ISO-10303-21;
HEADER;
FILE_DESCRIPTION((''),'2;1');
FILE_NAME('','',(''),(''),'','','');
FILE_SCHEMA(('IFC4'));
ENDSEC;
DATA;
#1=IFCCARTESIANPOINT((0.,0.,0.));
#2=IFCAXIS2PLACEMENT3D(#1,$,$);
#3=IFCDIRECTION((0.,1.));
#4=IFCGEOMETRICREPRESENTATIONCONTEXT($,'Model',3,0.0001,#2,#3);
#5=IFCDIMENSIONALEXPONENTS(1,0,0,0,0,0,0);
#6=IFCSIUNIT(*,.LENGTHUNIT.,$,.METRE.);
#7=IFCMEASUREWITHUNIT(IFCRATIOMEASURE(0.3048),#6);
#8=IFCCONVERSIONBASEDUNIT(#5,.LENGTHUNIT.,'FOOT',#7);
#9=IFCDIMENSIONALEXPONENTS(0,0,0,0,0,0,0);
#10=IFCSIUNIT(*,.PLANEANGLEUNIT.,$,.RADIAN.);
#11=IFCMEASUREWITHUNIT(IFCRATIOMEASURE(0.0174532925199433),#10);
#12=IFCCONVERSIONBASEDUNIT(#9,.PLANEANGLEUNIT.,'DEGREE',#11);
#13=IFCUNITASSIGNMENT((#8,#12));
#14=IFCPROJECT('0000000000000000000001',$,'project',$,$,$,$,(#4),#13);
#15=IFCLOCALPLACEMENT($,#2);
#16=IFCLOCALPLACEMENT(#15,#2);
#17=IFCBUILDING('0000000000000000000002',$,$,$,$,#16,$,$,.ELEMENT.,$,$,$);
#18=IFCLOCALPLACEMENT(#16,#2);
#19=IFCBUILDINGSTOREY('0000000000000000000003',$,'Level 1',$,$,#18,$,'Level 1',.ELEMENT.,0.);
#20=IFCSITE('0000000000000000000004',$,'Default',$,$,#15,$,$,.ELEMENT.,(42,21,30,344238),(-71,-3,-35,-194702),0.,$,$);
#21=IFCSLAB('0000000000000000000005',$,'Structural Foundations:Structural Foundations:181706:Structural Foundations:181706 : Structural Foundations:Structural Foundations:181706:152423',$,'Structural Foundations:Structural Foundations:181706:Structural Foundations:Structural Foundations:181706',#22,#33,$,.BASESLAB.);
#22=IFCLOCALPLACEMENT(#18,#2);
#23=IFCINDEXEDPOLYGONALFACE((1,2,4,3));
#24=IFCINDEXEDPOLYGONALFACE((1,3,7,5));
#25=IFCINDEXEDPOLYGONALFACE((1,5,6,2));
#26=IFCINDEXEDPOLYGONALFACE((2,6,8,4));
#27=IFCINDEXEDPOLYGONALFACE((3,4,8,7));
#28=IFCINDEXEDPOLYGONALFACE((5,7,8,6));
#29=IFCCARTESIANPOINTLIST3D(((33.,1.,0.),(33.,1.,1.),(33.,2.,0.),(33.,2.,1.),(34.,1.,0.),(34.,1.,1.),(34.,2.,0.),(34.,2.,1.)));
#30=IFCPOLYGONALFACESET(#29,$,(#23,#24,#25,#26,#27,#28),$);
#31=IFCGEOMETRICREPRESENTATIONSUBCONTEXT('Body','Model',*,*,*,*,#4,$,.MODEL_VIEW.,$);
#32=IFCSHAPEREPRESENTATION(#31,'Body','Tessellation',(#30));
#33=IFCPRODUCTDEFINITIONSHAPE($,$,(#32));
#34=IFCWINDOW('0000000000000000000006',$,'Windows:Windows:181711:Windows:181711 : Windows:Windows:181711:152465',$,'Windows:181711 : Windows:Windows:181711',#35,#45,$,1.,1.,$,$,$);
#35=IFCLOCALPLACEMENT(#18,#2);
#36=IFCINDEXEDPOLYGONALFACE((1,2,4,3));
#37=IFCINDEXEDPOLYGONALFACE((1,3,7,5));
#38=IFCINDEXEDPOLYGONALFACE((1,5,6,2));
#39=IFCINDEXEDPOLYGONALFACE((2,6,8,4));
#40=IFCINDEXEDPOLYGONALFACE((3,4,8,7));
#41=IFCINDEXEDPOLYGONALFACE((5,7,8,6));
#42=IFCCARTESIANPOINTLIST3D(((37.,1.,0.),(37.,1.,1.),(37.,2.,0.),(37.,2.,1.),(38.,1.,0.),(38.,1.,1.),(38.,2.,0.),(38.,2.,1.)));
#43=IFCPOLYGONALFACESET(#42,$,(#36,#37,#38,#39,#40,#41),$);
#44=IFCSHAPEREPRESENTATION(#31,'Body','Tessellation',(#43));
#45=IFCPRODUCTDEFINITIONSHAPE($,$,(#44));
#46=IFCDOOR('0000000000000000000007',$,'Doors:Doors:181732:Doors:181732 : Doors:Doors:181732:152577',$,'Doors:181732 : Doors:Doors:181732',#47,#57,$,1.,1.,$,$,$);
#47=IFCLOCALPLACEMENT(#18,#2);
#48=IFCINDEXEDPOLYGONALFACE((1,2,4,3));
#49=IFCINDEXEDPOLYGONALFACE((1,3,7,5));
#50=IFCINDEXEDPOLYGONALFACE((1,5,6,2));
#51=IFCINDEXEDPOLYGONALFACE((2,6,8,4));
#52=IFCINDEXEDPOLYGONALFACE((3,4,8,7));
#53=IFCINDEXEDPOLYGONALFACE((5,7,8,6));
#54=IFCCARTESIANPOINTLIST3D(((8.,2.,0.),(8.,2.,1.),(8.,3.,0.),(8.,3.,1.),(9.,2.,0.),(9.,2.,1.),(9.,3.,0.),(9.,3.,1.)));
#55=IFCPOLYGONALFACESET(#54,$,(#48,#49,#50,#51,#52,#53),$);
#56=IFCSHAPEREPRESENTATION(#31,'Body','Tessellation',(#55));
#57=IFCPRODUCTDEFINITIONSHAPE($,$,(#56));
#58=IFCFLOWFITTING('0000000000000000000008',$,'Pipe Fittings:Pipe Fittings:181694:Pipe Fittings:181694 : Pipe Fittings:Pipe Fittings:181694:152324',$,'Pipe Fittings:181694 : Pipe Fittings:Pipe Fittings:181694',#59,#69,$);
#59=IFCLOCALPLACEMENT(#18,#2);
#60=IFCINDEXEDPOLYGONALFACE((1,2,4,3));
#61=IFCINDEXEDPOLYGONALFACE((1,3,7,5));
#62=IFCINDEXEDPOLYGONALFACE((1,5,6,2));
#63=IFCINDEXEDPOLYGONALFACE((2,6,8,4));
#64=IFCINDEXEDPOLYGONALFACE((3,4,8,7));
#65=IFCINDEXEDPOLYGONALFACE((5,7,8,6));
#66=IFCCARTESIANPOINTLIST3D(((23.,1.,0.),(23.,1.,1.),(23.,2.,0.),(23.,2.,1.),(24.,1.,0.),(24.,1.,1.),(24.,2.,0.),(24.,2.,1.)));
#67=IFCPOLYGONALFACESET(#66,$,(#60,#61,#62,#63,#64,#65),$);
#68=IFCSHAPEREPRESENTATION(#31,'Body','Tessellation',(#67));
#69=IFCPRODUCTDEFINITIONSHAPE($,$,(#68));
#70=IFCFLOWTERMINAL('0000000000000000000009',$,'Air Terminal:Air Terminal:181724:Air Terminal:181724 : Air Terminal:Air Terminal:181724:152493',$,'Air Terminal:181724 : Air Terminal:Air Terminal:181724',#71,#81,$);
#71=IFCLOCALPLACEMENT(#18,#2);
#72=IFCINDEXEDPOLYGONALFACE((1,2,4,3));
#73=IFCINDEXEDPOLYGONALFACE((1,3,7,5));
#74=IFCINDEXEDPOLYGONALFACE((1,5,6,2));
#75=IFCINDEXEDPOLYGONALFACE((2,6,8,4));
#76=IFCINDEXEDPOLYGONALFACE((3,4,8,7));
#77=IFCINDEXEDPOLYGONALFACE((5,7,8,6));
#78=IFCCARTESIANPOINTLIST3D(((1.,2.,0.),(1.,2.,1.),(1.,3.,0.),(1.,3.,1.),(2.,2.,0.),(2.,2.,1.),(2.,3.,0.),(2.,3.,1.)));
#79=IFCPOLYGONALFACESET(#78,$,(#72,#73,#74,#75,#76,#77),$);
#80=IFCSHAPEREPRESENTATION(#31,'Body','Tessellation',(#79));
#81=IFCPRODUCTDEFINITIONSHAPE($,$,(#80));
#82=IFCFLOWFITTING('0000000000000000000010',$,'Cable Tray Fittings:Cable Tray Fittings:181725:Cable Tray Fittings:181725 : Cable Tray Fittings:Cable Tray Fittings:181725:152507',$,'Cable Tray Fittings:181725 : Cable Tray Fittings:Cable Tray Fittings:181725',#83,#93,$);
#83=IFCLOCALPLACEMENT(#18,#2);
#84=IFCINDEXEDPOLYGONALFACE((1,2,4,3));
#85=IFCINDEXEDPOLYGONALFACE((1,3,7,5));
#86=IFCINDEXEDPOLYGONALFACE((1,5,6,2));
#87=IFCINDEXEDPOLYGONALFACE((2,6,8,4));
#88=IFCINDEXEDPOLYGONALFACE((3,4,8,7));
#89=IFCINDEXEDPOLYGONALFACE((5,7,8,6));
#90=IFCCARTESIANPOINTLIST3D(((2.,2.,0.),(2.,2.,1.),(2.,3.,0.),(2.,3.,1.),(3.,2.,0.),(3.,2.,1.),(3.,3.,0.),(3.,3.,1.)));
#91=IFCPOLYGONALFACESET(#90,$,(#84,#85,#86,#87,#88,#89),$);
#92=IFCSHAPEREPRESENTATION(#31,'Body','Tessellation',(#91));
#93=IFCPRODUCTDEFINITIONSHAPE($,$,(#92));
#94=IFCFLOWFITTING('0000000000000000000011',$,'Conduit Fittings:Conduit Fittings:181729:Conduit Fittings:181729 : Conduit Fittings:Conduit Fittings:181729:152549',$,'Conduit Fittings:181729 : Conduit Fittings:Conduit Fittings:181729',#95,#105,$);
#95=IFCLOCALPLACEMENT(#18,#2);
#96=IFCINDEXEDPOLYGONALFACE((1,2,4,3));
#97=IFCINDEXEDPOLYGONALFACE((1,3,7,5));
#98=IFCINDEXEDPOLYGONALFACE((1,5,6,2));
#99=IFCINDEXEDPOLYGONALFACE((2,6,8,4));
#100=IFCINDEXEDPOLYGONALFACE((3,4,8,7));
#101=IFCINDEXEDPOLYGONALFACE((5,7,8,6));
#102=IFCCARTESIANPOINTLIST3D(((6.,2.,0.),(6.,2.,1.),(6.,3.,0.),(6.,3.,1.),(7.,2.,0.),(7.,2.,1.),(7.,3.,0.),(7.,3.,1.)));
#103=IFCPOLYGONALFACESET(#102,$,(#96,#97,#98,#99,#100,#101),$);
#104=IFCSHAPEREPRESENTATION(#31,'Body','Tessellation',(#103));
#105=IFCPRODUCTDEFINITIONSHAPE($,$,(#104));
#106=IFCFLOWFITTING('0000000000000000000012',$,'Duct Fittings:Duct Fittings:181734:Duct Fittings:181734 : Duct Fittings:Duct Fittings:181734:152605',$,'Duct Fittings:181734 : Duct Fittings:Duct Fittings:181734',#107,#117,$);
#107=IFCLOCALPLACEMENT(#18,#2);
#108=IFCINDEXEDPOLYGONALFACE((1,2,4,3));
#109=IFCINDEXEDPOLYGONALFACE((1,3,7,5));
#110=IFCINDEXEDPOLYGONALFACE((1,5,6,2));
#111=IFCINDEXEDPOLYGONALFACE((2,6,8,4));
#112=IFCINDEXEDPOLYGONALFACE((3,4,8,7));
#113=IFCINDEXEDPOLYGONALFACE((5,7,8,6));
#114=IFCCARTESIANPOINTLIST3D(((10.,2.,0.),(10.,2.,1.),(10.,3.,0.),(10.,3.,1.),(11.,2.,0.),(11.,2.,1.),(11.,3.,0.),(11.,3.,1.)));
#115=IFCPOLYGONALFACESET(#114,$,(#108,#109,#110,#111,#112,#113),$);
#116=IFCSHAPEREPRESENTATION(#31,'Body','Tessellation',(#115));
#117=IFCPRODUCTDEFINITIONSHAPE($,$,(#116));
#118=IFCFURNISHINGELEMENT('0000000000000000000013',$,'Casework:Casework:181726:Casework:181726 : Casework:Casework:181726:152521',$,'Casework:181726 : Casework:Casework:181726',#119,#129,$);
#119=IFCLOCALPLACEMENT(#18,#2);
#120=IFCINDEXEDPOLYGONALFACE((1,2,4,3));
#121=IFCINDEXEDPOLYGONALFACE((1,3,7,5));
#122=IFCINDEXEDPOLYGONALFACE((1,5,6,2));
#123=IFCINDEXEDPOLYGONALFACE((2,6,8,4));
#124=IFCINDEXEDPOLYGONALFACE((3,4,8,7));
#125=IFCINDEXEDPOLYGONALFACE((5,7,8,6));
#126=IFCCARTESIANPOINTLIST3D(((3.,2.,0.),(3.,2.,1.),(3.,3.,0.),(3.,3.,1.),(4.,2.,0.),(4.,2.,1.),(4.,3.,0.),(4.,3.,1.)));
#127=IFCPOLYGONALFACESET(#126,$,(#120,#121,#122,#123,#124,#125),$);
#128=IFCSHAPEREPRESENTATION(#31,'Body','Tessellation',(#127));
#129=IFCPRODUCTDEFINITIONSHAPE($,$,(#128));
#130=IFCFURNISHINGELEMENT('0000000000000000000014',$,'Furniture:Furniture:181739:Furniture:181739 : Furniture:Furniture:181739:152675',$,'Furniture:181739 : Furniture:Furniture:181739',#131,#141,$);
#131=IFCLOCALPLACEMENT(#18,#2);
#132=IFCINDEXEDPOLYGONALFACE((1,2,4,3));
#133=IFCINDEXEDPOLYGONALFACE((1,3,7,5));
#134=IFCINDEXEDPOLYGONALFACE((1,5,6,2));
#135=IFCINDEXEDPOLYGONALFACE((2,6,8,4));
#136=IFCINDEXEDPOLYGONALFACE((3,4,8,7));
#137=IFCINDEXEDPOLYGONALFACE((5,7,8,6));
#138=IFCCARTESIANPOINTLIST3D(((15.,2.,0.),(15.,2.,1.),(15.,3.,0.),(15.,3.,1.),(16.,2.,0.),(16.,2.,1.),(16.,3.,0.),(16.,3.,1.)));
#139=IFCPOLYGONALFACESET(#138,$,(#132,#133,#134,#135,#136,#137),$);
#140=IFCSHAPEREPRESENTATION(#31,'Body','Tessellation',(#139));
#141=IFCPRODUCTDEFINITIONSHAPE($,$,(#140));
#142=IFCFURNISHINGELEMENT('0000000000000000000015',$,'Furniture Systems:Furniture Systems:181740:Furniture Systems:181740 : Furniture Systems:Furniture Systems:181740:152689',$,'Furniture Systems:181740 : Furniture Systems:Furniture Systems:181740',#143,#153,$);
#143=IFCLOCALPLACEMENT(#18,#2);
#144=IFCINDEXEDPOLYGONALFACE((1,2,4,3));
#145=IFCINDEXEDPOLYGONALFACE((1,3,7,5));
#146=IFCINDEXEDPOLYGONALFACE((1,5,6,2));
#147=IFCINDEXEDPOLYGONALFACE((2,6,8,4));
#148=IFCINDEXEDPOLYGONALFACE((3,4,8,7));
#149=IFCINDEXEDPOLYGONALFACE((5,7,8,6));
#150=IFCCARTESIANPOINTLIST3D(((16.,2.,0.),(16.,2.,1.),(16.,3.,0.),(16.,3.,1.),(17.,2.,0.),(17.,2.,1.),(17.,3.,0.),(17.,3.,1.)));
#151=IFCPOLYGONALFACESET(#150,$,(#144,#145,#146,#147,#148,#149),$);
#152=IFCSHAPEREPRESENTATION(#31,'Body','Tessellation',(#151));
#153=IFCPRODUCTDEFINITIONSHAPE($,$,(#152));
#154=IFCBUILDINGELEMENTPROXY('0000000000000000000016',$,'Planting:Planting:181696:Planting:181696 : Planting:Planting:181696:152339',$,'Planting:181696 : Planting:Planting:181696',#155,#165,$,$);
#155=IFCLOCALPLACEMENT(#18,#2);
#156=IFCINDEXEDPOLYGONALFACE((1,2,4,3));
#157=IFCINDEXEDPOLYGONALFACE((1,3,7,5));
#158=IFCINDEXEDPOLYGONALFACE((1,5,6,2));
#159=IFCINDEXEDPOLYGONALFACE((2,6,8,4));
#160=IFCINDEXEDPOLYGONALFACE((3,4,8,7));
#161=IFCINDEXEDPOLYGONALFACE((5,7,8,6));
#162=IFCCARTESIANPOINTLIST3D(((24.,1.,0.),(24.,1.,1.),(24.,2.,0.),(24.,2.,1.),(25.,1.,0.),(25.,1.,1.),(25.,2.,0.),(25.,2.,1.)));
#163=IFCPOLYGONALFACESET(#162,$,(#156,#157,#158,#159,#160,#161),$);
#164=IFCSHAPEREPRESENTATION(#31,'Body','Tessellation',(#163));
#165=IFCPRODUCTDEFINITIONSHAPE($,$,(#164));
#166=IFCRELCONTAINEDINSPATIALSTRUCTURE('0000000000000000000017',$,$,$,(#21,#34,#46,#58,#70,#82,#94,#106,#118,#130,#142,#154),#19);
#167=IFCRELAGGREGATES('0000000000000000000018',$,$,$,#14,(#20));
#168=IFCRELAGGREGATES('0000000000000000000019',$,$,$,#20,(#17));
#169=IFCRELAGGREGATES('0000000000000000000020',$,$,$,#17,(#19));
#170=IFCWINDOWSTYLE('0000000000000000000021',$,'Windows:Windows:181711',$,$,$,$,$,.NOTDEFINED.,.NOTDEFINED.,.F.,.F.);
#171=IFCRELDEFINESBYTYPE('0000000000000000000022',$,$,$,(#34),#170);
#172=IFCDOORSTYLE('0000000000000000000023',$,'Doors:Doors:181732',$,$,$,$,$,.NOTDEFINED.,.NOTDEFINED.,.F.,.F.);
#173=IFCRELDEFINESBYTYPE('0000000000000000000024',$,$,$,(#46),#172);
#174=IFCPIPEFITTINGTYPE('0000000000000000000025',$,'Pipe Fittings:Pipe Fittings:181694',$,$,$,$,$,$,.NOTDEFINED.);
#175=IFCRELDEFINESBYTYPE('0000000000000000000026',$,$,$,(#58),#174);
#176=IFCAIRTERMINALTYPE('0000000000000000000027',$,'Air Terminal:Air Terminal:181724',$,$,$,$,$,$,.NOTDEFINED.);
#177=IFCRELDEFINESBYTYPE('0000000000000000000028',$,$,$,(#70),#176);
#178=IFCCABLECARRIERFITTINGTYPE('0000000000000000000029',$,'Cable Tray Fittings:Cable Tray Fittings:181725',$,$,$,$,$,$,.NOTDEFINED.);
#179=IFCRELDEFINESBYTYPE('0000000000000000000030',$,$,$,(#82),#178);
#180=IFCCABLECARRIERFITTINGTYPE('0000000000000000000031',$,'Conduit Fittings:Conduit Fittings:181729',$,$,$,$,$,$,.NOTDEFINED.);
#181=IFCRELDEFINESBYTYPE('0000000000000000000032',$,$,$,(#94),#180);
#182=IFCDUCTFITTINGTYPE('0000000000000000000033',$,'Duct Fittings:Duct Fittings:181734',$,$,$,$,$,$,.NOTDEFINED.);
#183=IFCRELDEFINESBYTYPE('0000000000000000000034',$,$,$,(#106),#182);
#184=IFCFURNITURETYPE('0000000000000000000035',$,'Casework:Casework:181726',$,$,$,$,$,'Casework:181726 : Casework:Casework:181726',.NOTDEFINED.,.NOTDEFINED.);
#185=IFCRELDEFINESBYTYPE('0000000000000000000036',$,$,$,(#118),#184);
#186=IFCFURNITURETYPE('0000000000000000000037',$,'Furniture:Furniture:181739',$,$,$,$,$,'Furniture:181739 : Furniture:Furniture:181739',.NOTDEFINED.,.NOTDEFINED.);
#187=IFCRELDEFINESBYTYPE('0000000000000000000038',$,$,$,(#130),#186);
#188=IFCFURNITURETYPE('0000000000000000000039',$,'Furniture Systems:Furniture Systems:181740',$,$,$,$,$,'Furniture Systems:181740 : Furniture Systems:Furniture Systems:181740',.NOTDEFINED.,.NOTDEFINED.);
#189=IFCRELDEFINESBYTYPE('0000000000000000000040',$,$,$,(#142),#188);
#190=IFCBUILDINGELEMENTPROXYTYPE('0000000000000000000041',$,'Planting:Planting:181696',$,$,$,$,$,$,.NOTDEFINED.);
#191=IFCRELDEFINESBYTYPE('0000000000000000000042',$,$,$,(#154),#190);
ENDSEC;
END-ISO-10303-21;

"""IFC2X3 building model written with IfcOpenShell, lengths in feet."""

from ifc_helpers import new_model, entity, si_unit, converted_unit, direction, frame, frame_2d, origin, place, context, subcontext, project, spatial, rectangle, extrude, source, transform, mapped, type_object, type_shapes, element, save


model = new_model("IFC2X3")

# Units and contexts
model_context = context("Model", 3, precision=0.0001, world=origin(), true_north=direction((0.0, 1.0)))
body_context = subcontext(model_context, "Body", "Model", "MODEL_VIEW")
ifc_project = project(units=[converted_unit("LENGTHUNIT", "FOOT", entity("IfcRatioMeasure", 0.3048), si_unit("LENGTHUNIT", "METRE"), dimensions=[1, 0, 0, 0, 0, 0, 0]), converted_unit("PLANEANGLEUNIT", "DEGREE", entity("IfcRatioMeasure", 0.0174532925199433), si_unit("PLANEANGLEUNIT", "RADIAN"), dimensions=[0, 0, 0, 0, 0, 0, 0])], contexts=[model_context])

# Site, building, storey
site_placement = place(None, origin())
site = spatial("IfcSite", under=ifc_project, at=site_placement, Name="Default", CompositionType="ELEMENT", RefLatitude=(42, 21, 30, 344238), RefLongitude=(-71, -3, -35, -194702), RefElevation=0.0)
building_placement = place(site_placement, origin())
building = spatial("IfcBuilding", under=site, at=building_placement, CompositionType="ELEMENT")
storey_placement = place(building_placement, origin())
storey = spatial("IfcBuildingStorey", under=building, at=storey_placement, Name="Level 1", LongName="Level 1", CompositionType="ELEMENT", Elevation=0.0)

# Slab
slab_placement = place(storey_placement, origin())
element("IfcSlab", 1, at=slab_placement, inside=storey, Name="Structural Foundations:Structural Foundations:181706:Structural Foundations:181706 : Structural Foundations:Structural Foundations:181706:152423", ObjectType="Structural Foundations:Structural Foundations:181706:Structural Foundations:Structural Foundations:181706", PredefinedType="BASESLAB", context=body_context, shape_type="SweptSolid", body=[
    extrude(rectangle(XDim=1.0, YDim=1.0, at=frame_2d((0.0, 0.0), x_axis=(1.0, 0.0))), frame((33.5, 1.5, 0.0), z_axis=(0.0, 0.0, 1.0), x_axis=(-1.0, 0.0, 0.0)), (0.0, 0.0, 1.0), 1.0),
])

# Window
window_style = type_object("IfcWindowStyle", Name="Windows:Windows:181711", ConstructionType="NOTDEFINED", OperationType="NOTDEFINED", ParameterTakesPrecedence=False, Sizeable=False)
shared_shape_1 = source(origin(), body_context, "Body", "SweptSolid", [
    extrude(rectangle(XDim=1.0, YDim=1.0, at=frame_2d((0.0, 0.0), x_axis=(1.0, 0.0))), frame((37.5, 1.5, 0.0), z_axis=(0.0, 0.0, 1.0), x_axis=(-1.0, 0.0, 0.0)), (0.0, 0.0, 1.0), 1.0),
])
type_shapes(window_style, [shared_shape_1])
window_placement = place(storey_placement, origin())
element("IfcWindow", 2, at=window_placement, inside=storey, type_object=window_style, Name="Windows:Windows:181711:Windows:181711 : Windows:Windows:181711:152465", ObjectType="Windows:181711 : Windows:Windows:181711", OverallHeight=1.0, OverallWidth=1.0, context=body_context, shape_type="MappedRepresentation", body=[
    mapped(shared_shape_1, transform((0.0, 0.0, 0.0), scale=1.0)),
])

# Door
door_style = type_object("IfcDoorStyle", Name="Doors:Doors:181732", ConstructionType="NOTDEFINED", OperationType="NOTDEFINED", ParameterTakesPrecedence=False, Sizeable=False)
shared_shape_2 = source(origin(), body_context, "Body", "SweptSolid", [
    extrude(rectangle(XDim=1.0, YDim=1.0, at=frame_2d((0.0, 0.0), x_axis=(1.0, 0.0))), frame((8.5, 2.5, 0.0), z_axis=(0.0, 0.0, 1.0), x_axis=(-1.0, 0.0, 0.0)), (0.0, 0.0, 1.0), 1.0),
])
type_shapes(door_style, [shared_shape_2])
door_placement = place(storey_placement, origin())
element("IfcDoor", 3, at=door_placement, inside=storey, type_object=door_style, Name="Doors:Doors:181732:Doors:181732 : Doors:Doors:181732:152577", ObjectType="Doors:181732 : Doors:Doors:181732", OverallHeight=1.0, OverallWidth=1.0, context=body_context, shape_type="MappedRepresentation", body=[
    mapped(shared_shape_2, transform((0.0, 0.0, 0.0), scale=1.0)),
])

# Flow fitting
pipe_fitting_type = type_object("IfcPipeFittingType", Name="Pipe Fittings:Pipe Fittings:181694", PredefinedType="NOTDEFINED")
shared_shape_3 = source(origin(), body_context, "Body", "SweptSolid", [
    extrude(rectangle(XDim=1.0, YDim=1.0, at=frame_2d((0.0, 0.0), x_axis=(1.0, 0.0))), frame((23.5, 1.5, 0.0), z_axis=(0.0, 0.0, 1.0), x_axis=(-1.0, 0.0, 0.0)), (0.0, 0.0, 1.0), 1.0),
])
type_shapes(pipe_fitting_type, [shared_shape_3])
flow_fitting_1_placement = place(storey_placement, origin())
element("IfcFlowFitting", 4, at=flow_fitting_1_placement, inside=storey, type_object=pipe_fitting_type, Name="Pipe Fittings:Pipe Fittings:181694:Pipe Fittings:181694 : Pipe Fittings:Pipe Fittings:181694:152324", ObjectType="Pipe Fittings:181694 : Pipe Fittings:Pipe Fittings:181694", context=body_context, shape_type="MappedRepresentation", body=[
    mapped(shared_shape_3, transform((0.0, 0.0, 0.0), scale=1.0)),
])

# Flow terminal
air_terminal_type = type_object("IfcAirTerminalType", Name="Air Terminal:Air Terminal:181724", PredefinedType="NOTDEFINED")
shared_shape_4 = source(origin(), body_context, "Body", "SweptSolid", [
    extrude(rectangle(XDim=1.0, YDim=1.0, at=frame_2d((0.0, 0.0), x_axis=(1.0, 0.0))), frame((1.5, 2.5, 0.0), z_axis=(0.0, 0.0, 1.0), x_axis=(-1.0, 0.0, 0.0)), (0.0, 0.0, 1.0), 1.0),
])
type_shapes(air_terminal_type, [shared_shape_4])
flow_terminal_placement = place(storey_placement, origin())
element("IfcFlowTerminal", 5, at=flow_terminal_placement, inside=storey, type_object=air_terminal_type, Name="Air Terminal:Air Terminal:181724:Air Terminal:181724 : Air Terminal:Air Terminal:181724:152493", ObjectType="Air Terminal:181724 : Air Terminal:Air Terminal:181724", context=body_context, shape_type="MappedRepresentation", body=[
    mapped(shared_shape_4, transform((0.0, 0.0, 0.0), scale=1.0)),
])

# Flow fittings
cable_carrier_fitting_type_1 = type_object("IfcCableCarrierFittingType", Name="Cable Tray Fittings:Cable Tray Fittings:181725", PredefinedType="NOTDEFINED")
shared_shape_5 = source(origin(), body_context, "Body", "SweptSolid", [
    extrude(rectangle(XDim=1.0, YDim=1.0, at=frame_2d((0.0, 0.0), x_axis=(1.0, 0.0))), frame((2.5, 2.5, 0.0), z_axis=(0.0, 0.0, 1.0), x_axis=(-1.0, 0.0, 0.0)), (0.0, 0.0, 1.0), 1.0),
])
type_shapes(cable_carrier_fitting_type_1, [shared_shape_5])
flow_fitting_2_placement = place(storey_placement, origin())
element("IfcFlowFitting", 6, at=flow_fitting_2_placement, inside=storey, type_object=cable_carrier_fitting_type_1, Name="Cable Tray Fittings:Cable Tray Fittings:181725:Cable Tray Fittings:181725 : Cable Tray Fittings:Cable Tray Fittings:181725:152507", ObjectType="Cable Tray Fittings:181725 : Cable Tray Fittings:Cable Tray Fittings:181725", context=body_context, shape_type="MappedRepresentation", body=[
    mapped(shared_shape_5, transform((0.0, 0.0, 0.0), scale=1.0)),
])
cable_carrier_fitting_type_2 = type_object("IfcCableCarrierFittingType", Name="Conduit Fittings:Conduit Fittings:181729", PredefinedType="NOTDEFINED")
shared_shape_6 = source(origin(), body_context, "Body", "SweptSolid", [
    extrude(rectangle(XDim=1.0, YDim=1.0, at=frame_2d((0.0, 0.0), x_axis=(1.0, 0.0))), frame((6.5, 2.5, 0.0), z_axis=(0.0, 0.0, 1.0), x_axis=(-1.0, 0.0, 0.0)), (0.0, 0.0, 1.0), 1.0),
])
type_shapes(cable_carrier_fitting_type_2, [shared_shape_6])
flow_fitting_3_placement = place(storey_placement, origin())
element("IfcFlowFitting", 7, at=flow_fitting_3_placement, inside=storey, type_object=cable_carrier_fitting_type_2, Name="Conduit Fittings:Conduit Fittings:181729:Conduit Fittings:181729 : Conduit Fittings:Conduit Fittings:181729:152549", ObjectType="Conduit Fittings:181729 : Conduit Fittings:Conduit Fittings:181729", context=body_context, shape_type="MappedRepresentation", body=[
    mapped(shared_shape_6, transform((0.0, 0.0, 0.0), scale=1.0)),
])
duct_fitting_type = type_object("IfcDuctFittingType", Name="Duct Fittings:Duct Fittings:181734", PredefinedType="NOTDEFINED")
shared_shape_7 = source(origin(), body_context, "Body", "SweptSolid", [
    extrude(rectangle(XDim=1.0, YDim=1.0, at=frame_2d((0.0, 0.0), x_axis=(1.0, 0.0))), frame((10.5, 2.5, 0.0), z_axis=(0.0, 0.0, 1.0), x_axis=(-1.0, 0.0, 0.0)), (0.0, 0.0, 1.0), 1.0),
])
type_shapes(duct_fitting_type, [shared_shape_7])
flow_fitting_4_placement = place(storey_placement, origin())
element("IfcFlowFitting", 8, at=flow_fitting_4_placement, inside=storey, type_object=duct_fitting_type, Name="Duct Fittings:Duct Fittings:181734:Duct Fittings:181734 : Duct Fittings:Duct Fittings:181734:152605", ObjectType="Duct Fittings:181734 : Duct Fittings:Duct Fittings:181734", context=body_context, shape_type="MappedRepresentation", body=[
    mapped(shared_shape_7, transform((0.0, 0.0, 0.0), scale=1.0)),
])

# Furnishing elements
furniture_type_1 = type_object("IfcFurnitureType", Name="Casework:Casework:181726", ElementType="Casework:181726 : Casework:Casework:181726")
shared_shape_8 = source(origin(), body_context, "Body", "SweptSolid", [
    extrude(rectangle(XDim=1.0, YDim=1.0, at=frame_2d((0.0, 0.0), x_axis=(1.0, 0.0))), frame((3.5, 2.5, 0.0), z_axis=(0.0, 0.0, 1.0), x_axis=(-1.0, 0.0, 0.0)), (0.0, 0.0, 1.0), 1.0),
])
type_shapes(furniture_type_1, [shared_shape_8])
furnishing_1_placement = place(storey_placement, origin())
element("IfcFurnishingElement", 9, at=furnishing_1_placement, inside=storey, type_object=furniture_type_1, Name="Casework:Casework:181726:Casework:181726 : Casework:Casework:181726:152521", ObjectType="Casework:181726 : Casework:Casework:181726", context=body_context, shape_type="MappedRepresentation", body=[
    mapped(shared_shape_8, transform((0.0, 0.0, 0.0), scale=1.0)),
])
furniture_type_2 = type_object("IfcFurnitureType", Name="Furniture:Furniture:181739", ElementType="Furniture:181739 : Furniture:Furniture:181739")
shared_shape_9 = source(origin(), body_context, "Body", "SweptSolid", [
    extrude(rectangle(XDim=1.0, YDim=1.0, at=frame_2d((0.0, 0.0), x_axis=(1.0, 0.0))), frame((15.5, 2.5, 0.0), z_axis=(0.0, 0.0, 1.0), x_axis=(-1.0, 0.0, 0.0)), (0.0, 0.0, 1.0), 1.0),
])
type_shapes(furniture_type_2, [shared_shape_9])
furnishing_2_placement = place(storey_placement, origin())
element("IfcFurnishingElement", 10, at=furnishing_2_placement, inside=storey, type_object=furniture_type_2, Name="Furniture:Furniture:181739:Furniture:181739 : Furniture:Furniture:181739:152675", ObjectType="Furniture:181739 : Furniture:Furniture:181739", context=body_context, shape_type="MappedRepresentation", body=[
    mapped(shared_shape_9, transform((0.0, 0.0, 0.0), scale=1.0)),
])
furniture_type_3 = type_object("IfcFurnitureType", Name="Furniture Systems:Furniture Systems:181740", ElementType="Furniture Systems:181740 : Furniture Systems:Furniture Systems:181740")
shared_shape_10 = source(origin(), body_context, "Body", "SweptSolid", [
    extrude(rectangle(XDim=1.0, YDim=1.0, at=frame_2d((0.0, 0.0), x_axis=(1.0, 0.0))), frame((16.5, 2.5, 0.0), z_axis=(0.0, 0.0, 1.0), x_axis=(-1.0, 0.0, 0.0)), (0.0, 0.0, 1.0), 1.0),
])
type_shapes(furniture_type_3, [shared_shape_10])
furnishing_3_placement = place(storey_placement, origin())
element("IfcFurnishingElement", 11, at=furnishing_3_placement, inside=storey, type_object=furniture_type_3, Name="Furniture Systems:Furniture Systems:181740:Furniture Systems:181740 : Furniture Systems:Furniture Systems:181740:152689", ObjectType="Furniture Systems:181740 : Furniture Systems:Furniture Systems:181740", context=body_context, shape_type="MappedRepresentation", body=[
    mapped(shared_shape_10, transform((0.0, 0.0, 0.0), scale=1.0)),
])

# Building element proxy
building_element_proxy_type_1 = type_object("IfcBuildingElementProxyType", Name="Planting:Planting:181696", PredefinedType="NOTDEFINED")
shared_shape_11 = source(origin(), body_context, "Body", "SweptSolid", [
    extrude(rectangle(XDim=1.0, YDim=1.0, at=frame_2d((0.0, 0.0), x_axis=(1.0, 0.0))), frame((24.5, 1.5, 0.0), z_axis=(0.0, 0.0, 1.0), x_axis=(-1.0, 0.0, 0.0)), (0.0, 0.0, 1.0), 1.0),
])
type_shapes(building_element_proxy_type_1, [shared_shape_11])
proxy_1_placement = place(storey_placement, origin())
element("IfcBuildingElementProxy", 12, at=proxy_1_placement, inside=storey, type_object=building_element_proxy_type_1, Name="Planting:Planting:181696:Planting:181696 : Planting:Planting:181696:152339", ObjectType="Planting:181696 : Planting:Planting:181696", context=body_context, shape_type="MappedRepresentation", body=[
    mapped(shared_shape_11, transform((0.0, 0.0, 0.0), scale=1.0)),
])

save(model, "model.ifc")
